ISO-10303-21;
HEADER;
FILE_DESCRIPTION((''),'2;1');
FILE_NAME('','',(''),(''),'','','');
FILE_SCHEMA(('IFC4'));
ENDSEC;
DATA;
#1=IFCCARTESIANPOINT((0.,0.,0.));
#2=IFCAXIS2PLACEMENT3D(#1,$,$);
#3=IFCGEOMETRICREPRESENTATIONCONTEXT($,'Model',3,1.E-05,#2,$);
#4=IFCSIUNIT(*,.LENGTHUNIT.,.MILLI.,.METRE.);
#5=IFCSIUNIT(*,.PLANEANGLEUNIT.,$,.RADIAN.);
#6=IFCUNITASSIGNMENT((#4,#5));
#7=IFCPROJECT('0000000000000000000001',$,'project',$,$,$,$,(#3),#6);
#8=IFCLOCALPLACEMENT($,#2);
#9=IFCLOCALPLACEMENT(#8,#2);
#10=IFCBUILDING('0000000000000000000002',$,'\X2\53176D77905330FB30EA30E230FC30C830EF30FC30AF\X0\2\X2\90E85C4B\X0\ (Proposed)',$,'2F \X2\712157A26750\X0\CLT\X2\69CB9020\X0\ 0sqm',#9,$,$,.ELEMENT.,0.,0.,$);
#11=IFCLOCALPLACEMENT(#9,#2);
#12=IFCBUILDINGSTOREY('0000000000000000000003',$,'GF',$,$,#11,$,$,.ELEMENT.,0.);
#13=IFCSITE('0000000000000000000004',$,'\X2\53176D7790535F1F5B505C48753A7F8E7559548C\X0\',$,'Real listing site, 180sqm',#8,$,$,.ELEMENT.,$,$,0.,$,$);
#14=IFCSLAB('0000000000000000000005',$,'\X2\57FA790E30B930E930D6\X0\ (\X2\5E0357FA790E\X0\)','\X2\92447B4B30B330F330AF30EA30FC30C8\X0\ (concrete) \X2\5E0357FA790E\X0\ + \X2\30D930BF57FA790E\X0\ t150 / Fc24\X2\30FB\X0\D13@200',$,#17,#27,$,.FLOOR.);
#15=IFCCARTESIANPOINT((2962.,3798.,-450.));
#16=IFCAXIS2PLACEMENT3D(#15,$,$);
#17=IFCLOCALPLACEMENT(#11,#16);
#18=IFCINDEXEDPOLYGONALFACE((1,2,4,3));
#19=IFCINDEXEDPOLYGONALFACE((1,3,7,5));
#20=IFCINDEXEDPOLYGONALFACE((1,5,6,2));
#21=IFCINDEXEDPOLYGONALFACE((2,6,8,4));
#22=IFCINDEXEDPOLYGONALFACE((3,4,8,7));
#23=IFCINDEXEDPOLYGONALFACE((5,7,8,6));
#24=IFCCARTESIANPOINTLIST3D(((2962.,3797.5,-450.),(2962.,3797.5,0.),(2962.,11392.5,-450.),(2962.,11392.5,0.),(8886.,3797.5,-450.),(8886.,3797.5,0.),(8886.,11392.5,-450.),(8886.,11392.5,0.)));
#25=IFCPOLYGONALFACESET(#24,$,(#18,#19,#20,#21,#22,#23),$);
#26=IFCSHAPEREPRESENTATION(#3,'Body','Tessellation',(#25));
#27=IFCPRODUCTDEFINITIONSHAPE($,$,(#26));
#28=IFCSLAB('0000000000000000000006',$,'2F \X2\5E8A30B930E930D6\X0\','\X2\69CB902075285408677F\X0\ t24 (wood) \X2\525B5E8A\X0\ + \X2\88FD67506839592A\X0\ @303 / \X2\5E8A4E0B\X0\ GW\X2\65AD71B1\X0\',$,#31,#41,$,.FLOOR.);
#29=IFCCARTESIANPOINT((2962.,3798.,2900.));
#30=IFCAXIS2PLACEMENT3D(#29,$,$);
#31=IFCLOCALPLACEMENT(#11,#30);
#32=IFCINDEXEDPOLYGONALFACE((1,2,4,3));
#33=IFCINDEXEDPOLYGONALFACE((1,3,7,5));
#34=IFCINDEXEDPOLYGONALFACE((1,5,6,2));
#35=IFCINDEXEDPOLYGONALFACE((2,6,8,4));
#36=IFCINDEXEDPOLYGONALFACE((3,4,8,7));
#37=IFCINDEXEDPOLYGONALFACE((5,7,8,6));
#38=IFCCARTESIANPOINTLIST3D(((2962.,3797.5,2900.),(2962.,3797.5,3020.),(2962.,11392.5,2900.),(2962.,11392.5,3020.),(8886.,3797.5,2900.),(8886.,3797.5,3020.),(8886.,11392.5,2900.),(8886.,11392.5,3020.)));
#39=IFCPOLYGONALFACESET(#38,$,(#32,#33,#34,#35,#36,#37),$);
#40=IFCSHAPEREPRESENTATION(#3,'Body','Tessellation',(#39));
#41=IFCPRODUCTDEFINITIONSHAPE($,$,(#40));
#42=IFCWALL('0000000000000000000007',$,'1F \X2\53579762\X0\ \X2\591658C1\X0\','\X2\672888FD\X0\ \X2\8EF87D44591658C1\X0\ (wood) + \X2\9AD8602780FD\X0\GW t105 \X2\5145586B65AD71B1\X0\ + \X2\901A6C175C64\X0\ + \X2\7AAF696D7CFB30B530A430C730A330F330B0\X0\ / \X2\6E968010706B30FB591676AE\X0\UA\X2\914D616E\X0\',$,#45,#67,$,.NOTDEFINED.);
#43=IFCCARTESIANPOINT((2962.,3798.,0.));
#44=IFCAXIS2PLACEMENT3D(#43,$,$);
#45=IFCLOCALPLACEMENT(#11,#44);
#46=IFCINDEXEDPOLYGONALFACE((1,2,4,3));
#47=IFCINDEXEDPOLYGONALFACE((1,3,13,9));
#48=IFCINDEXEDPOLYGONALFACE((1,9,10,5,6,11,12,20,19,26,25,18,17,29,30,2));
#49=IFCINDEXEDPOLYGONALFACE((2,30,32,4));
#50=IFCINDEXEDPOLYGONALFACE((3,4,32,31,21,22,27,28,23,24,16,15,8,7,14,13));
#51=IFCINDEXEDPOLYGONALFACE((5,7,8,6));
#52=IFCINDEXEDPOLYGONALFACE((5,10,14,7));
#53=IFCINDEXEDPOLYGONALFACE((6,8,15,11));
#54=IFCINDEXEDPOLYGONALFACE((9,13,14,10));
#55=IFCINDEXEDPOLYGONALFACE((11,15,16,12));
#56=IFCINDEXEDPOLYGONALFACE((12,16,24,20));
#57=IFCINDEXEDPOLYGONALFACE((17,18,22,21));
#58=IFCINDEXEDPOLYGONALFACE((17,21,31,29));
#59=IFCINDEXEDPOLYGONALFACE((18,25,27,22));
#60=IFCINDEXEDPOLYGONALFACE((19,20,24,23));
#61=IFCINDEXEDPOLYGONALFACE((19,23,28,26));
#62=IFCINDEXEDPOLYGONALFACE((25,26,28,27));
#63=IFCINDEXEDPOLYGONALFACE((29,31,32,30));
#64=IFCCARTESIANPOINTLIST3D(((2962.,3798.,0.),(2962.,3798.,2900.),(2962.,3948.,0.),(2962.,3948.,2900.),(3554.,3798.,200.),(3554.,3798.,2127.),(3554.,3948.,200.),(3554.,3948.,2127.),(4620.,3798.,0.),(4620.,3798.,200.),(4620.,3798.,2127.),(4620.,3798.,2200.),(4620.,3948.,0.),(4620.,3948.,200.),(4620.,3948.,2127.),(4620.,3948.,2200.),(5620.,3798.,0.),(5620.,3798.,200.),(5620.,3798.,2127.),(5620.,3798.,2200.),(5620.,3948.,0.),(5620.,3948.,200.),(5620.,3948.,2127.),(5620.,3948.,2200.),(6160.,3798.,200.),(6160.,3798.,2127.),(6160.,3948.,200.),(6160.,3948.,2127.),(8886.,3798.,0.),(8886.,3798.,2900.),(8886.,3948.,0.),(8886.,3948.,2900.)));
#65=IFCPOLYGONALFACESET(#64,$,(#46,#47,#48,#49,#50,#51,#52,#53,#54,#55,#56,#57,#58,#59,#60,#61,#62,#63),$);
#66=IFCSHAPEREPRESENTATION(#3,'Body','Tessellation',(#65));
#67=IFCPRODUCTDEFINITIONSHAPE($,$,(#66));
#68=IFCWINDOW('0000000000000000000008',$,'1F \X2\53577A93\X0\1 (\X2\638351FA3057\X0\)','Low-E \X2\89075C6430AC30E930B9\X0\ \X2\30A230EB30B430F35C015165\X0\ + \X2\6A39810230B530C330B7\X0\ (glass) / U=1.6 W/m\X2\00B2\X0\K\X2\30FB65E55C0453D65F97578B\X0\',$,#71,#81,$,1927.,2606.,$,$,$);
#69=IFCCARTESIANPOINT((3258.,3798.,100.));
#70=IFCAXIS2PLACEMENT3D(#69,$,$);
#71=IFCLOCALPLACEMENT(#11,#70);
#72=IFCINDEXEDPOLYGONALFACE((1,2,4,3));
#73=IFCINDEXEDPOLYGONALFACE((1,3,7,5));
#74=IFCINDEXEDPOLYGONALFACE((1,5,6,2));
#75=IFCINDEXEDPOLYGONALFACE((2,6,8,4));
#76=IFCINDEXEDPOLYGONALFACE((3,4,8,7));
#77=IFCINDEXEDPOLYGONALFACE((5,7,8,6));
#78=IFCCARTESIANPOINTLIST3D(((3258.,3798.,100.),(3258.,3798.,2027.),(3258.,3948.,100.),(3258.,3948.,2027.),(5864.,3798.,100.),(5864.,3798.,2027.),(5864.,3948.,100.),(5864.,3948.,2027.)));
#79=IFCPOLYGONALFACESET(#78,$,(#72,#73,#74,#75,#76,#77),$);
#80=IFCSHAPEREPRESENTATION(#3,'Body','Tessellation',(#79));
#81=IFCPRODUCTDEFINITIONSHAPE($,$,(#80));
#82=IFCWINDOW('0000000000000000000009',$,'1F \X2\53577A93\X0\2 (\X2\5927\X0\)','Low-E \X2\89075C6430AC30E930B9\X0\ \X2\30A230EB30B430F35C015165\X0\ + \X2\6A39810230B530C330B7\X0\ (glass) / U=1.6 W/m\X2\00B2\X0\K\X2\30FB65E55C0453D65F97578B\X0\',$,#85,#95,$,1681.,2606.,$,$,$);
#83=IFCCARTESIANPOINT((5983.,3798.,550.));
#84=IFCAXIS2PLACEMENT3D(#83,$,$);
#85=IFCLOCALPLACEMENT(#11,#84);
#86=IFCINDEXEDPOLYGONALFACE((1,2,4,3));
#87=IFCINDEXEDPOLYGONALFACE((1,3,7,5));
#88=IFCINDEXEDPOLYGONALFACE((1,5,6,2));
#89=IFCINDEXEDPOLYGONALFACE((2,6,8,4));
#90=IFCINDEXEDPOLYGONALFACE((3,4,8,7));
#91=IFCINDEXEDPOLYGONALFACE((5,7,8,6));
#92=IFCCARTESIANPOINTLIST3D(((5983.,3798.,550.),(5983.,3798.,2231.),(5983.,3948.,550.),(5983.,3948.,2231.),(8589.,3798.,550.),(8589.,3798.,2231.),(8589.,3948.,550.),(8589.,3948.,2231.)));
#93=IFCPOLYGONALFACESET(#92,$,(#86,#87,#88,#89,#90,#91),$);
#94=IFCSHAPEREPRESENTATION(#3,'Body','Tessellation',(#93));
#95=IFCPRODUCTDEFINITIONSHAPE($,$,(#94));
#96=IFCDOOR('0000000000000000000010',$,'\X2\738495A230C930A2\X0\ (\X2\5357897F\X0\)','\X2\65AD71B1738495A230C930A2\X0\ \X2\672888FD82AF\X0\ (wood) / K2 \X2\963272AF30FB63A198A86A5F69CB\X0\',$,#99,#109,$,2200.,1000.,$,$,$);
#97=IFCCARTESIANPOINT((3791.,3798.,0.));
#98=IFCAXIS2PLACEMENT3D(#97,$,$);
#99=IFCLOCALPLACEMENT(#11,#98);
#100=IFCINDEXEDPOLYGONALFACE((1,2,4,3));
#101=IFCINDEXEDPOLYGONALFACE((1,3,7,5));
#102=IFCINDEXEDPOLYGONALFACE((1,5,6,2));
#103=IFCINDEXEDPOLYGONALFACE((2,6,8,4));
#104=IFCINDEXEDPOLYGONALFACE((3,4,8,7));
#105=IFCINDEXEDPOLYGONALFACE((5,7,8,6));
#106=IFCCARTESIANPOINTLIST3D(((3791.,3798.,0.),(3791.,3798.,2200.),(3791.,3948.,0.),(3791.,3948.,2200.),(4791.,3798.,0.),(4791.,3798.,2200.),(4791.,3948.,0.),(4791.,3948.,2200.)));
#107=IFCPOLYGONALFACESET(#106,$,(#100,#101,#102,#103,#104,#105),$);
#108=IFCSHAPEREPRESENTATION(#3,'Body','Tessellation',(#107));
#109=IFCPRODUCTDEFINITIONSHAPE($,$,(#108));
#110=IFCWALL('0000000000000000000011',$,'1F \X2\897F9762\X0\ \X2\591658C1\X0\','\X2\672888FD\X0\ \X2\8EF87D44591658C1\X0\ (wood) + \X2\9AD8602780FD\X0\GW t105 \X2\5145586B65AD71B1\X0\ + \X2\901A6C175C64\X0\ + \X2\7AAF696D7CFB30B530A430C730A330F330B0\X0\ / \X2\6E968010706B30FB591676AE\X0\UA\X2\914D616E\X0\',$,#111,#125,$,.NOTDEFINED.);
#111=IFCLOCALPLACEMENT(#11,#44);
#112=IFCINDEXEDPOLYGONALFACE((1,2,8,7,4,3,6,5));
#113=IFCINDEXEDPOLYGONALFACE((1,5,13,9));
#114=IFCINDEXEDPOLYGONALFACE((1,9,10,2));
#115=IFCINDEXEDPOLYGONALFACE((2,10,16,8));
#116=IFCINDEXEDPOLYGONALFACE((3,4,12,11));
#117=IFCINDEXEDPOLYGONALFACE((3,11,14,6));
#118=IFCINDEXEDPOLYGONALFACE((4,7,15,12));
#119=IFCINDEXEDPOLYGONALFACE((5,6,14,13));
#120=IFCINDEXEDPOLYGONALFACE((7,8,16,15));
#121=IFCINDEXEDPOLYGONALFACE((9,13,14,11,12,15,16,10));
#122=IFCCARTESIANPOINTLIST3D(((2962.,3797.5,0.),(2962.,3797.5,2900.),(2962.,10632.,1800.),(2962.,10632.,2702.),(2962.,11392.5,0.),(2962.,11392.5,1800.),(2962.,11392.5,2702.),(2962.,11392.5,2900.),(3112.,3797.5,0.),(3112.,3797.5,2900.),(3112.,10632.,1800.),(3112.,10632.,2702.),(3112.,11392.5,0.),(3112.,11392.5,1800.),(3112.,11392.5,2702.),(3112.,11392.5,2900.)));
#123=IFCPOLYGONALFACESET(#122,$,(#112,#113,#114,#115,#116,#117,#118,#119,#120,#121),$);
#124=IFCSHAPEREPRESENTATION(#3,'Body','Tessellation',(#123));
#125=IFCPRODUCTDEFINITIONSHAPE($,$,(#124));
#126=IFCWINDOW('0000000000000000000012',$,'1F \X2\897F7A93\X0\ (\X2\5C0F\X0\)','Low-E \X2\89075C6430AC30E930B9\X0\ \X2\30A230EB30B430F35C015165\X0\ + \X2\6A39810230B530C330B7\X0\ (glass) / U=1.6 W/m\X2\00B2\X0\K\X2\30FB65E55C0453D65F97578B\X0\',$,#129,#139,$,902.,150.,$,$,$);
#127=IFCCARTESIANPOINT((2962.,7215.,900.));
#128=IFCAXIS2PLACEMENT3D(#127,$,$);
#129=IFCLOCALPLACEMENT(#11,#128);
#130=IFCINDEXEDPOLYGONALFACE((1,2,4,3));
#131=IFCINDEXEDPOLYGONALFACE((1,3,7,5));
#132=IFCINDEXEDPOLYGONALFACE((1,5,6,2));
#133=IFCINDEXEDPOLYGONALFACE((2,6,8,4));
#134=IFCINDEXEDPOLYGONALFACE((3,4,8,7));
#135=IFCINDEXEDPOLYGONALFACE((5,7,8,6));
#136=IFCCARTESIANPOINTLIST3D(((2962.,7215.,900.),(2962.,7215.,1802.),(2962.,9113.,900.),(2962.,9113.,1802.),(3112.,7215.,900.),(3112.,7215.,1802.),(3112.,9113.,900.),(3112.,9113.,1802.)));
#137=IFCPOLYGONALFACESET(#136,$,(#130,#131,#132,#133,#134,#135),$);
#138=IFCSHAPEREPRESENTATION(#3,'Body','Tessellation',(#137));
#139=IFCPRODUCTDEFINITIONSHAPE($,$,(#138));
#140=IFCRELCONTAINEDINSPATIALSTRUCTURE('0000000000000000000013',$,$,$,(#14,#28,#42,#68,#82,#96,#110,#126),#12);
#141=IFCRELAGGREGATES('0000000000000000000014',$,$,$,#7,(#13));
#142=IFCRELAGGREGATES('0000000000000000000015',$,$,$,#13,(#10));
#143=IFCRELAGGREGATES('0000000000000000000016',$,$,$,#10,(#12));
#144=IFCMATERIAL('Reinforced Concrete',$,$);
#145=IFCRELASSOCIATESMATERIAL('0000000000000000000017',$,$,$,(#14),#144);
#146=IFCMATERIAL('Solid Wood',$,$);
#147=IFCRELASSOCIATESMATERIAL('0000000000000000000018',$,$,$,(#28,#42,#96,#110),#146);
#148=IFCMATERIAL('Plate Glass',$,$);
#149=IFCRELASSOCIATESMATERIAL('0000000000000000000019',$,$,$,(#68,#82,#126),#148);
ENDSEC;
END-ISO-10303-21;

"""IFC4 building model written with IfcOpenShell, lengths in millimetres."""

from ifc_helpers import new_model, si_unit, frame, frame_2d, origin, place, context, project, spatial, rectangle, extrude, material, element, fill, save


model = new_model("IFC4")

# Units and contexts
model_context = context("Model", 3, precision=1e-05, world=origin())
ifc_project = project(units=[si_unit("LENGTHUNIT", "METRE", prefix="MILLI"), si_unit("PLANEANGLEUNIT", "RADIAN")], contexts=[model_context])

# Site, building, storey
site_placement = place(None, origin())
site = spatial("IfcSite", under=ifc_project, at=site_placement, Name="北海道弟子屈町美留和", ObjectType="Real listing site, 180sqm", CompositionType="ELEMENT", RefElevation=0.0)
building_placement = place(site_placement, origin())
building = spatial("IfcBuilding", under=site, at=building_placement, Name="北海道・リモートワーク2部屋 (Proposed)", ObjectType="2F 無垢材CLT構造 0sqm", CompositionType="ELEMENT", ElevationOfRefHeight=0.0, ElevationOfTerrain=0.0)
storey_placement = place(building_placement, origin())
storey = spatial("IfcBuildingStorey", under=building, at=storey_placement, Name="GF", CompositionType="ELEMENT", Elevation=0.0)

# Slabs
ifc_material_1 = material(Name="Reinforced Concrete")
slab_1_placement = place(storey_placement, frame((2962.0, 3798.0, -450.0)))
element("IfcSlab", 1, at=slab_1_placement, inside=storey, material=ifc_material_1, Name="基礎スラブ (布基礎)", Description="鉄筋コンクリート (concrete) 布基礎 + ベタ基礎 t150 / Fc24・D13@200", PredefinedType="FLOOR", context=model_context, shape_type="SweptSolid", body=[
    extrude(rectangle(XDim=5924.0, YDim=7595.0, at=frame_2d((2962.0, 3797.0))), frame((2962.0, 3798.0, -450.0)), (0.0, 0.0, 1.0), 450.0),
])
ifc_material_2 = material(Name="Solid Wood")
slab_2_placement = place(storey_placement, frame((2962.0, 3798.0, 2900.0)))
element("IfcSlab", 2, at=slab_2_placement, inside=storey, material=ifc_material_2, Name="2F 床スラブ", Description="構造用合板 t24 (wood) 剛床 + 製材根太 @303 / 床下 GW断熱", PredefinedType="FLOOR", context=model_context, shape_type="SweptSolid", body=[
    extrude(rectangle(XDim=5924.0, YDim=7595.0, at=frame_2d((2962.0, 3797.0))), frame((2962.0, 3798.0, 2900.0)), (0.0, 0.0, 1.0), 120.0),
])

# Wall, openings, windows, door
wall_1_placement = place(storey_placement, frame((2962.0, 3798.0, 0.0)))
wall_1 = element("IfcWall", 3, at=wall_1_placement, inside=storey, material=ifc_material_2, Name="1F 南面 外壁", Description="木製 軸組外壁 (wood) + 高性能GW t105 充填断熱 + 通気層 + 窯業系サイディング / 準耐火・外皮UA配慮", PredefinedType="NOTDEFINED", context=model_context, shape_type="SweptSolid", body=[
    extrude(rectangle(XDim=5924.0, YDim=150.0, at=frame_2d((2962.0, 75.0))), frame((2962.0, 3798.0, 0.0)), (0.0, 0.0, 1.0), 2900.0),
])
opening_1_placement = place(storey_placement, frame((3258.0, 3798.0, 100.0)))
opening_1 = element("IfcOpeningElement", 4, at=opening_1_placement, cuts=wall_1, PredefinedType="NOTDEFINED", context=model_context, shape_type="SweptSolid", body=[
    extrude(rectangle(XDim=2606.0, YDim=150.0, at=frame_2d((1303.0, 75.0))), frame((3258.0, 3798.0, 100.0)), (0.0, 0.0, 1.0), 1927.0),
])
opening_2_placement = place(storey_placement, frame((5983.0, 3798.0, 550.0)))
opening_2 = element("IfcOpeningElement", 5, at=opening_2_placement, cuts=wall_1, PredefinedType="NOTDEFINED", context=model_context, shape_type="SweptSolid", body=[
    extrude(rectangle(XDim=2606.0, YDim=150.0, at=frame_2d((1303.0, 75.0))), frame((5983.0, 3798.0, 550.0)), (0.0, 0.0, 1.0), 1681.0),
])
opening_3_placement = place(storey_placement, frame((3791.0, 3798.0, 0.0)))
opening_3 = element("IfcOpeningElement", 6, at=opening_3_placement, cuts=wall_1, PredefinedType="NOTDEFINED", context=model_context, shape_type="SweptSolid", body=[
    extrude(rectangle(XDim=1000.0, YDim=150.0, at=frame_2d((500.0, 75.0))), frame((3791.0, 3798.0, 0.0)), (0.0, 0.0, 1.0), 2200.0),
])
ifc_material_3 = material(Name="Plate Glass")
window_1_placement = place(storey_placement, frame((3258.0, 3798.0, 100.0)))
window_1 = element("IfcWindow", 7, at=window_1_placement, inside=storey, material=ifc_material_3, Name="1F 南窓1 (掃出し)", Description="Low-E 複層ガラス アルゴン封入 + 樹脂サッシ (glass) / U=1.6 W/m²K・日射取得型", OverallHeight=1927.0, OverallWidth=2606.0, context=model_context, shape_type="SweptSolid", body=[
    extrude(rectangle(XDim=2606.0, YDim=150.0, at=frame_2d((1303.0, 75.0))), frame((3258.0, 3798.0, 100.0)), (0.0, 0.0, 1.0), 1927.0),
])
fill(opening_1, window_1)
window_2_placement = place(storey_placement, frame((5983.0, 3798.0, 550.0)))
window_2 = element("IfcWindow", 8, at=window_2_placement, inside=storey, material=ifc_material_3, Name="1F 南窓2 (大)", Description="Low-E 複層ガラス アルゴン封入 + 樹脂サッシ (glass) / U=1.6 W/m²K・日射取得型", OverallHeight=1681.0, OverallWidth=2606.0, context=model_context, shape_type="SweptSolid", body=[
    extrude(rectangle(XDim=2606.0, YDim=150.0, at=frame_2d((1303.0, 75.0))), frame((5983.0, 3798.0, 550.0)), (0.0, 0.0, 1.0), 1681.0),
])
fill(opening_2, window_2)
door_placement = place(storey_placement, frame((3791.0, 3798.0, 0.0)))
door = element("IfcDoor", 9, at=door_placement, inside=storey, material=ifc_material_2, Name="玄関ドア (南西)", Description="断熱玄関ドア 木製芯 (wood) / K2 防犯・採風機構", OverallHeight=2200.0, OverallWidth=1000.0, context=model_context, shape_type="SweptSolid", body=[
    extrude(rectangle(XDim=1000.0, YDim=150.0, at=frame_2d((500.0, 75.0))), frame((3791.0, 3798.0, 0.0)), (0.0, 0.0, 1.0), 2200.0),
])
fill(opening_3, door)

# Wall, opening, window
wall_2_placement = place(storey_placement, frame((2962.0, 3798.0, 0.0)))
wall_2 = element("IfcWall", 10, at=wall_2_placement, inside=storey, material=ifc_material_2, Name="1F 西面 外壁", Description="木製 軸組外壁 (wood) + 高性能GW t105 充填断熱 + 通気層 + 窯業系サイディング / 準耐火・外皮UA配慮", PredefinedType="NOTDEFINED", context=model_context, shape_type="SweptSolid", body=[
    extrude(rectangle(XDim=150.0, YDim=7595.0, at=frame_2d((75.0, 3797.0))), frame((2962.0, 3798.0, 0.0)), (0.0, 0.0, 1.0), 2900.0),
])
opening_4_placement = place(storey_placement, frame((2962.0, 7215.0, 900.0)))
opening_4 = element("IfcOpeningElement", 11, at=opening_4_placement, cuts=wall_2, PredefinedType="NOTDEFINED", context=model_context, shape_type="SweptSolid", body=[
    extrude(rectangle(XDim=150.0, YDim=1898.0, at=frame_2d((75.0, 949.0))), frame((2962.0, 7215.0, 900.0)), (0.0, 0.0, 1.0), 902.0),
])
window_3_placement = place(storey_placement, frame((2962.0, 7215.0, 900.0)))
window_3 = element("IfcWindow", 12, at=window_3_placement, inside=storey, material=ifc_material_3, Name="1F 西窓 (小)", Description="Low-E 複層ガラス アルゴン封入 + 樹脂サッシ (glass) / U=1.6 W/m²K・日射取得型", OverallHeight=902.0, OverallWidth=150.0, context=model_context, shape_type="SweptSolid", body=[
    extrude(rectangle(XDim=150.0, YDim=1898.0, at=frame_2d((75.0, 949.0))), frame((2962.0, 7215.0, 900.0)), (0.0, 0.0, 1.0), 902.0),
])
fill(opening_4, window_3)

save(model, "model.ifc")
